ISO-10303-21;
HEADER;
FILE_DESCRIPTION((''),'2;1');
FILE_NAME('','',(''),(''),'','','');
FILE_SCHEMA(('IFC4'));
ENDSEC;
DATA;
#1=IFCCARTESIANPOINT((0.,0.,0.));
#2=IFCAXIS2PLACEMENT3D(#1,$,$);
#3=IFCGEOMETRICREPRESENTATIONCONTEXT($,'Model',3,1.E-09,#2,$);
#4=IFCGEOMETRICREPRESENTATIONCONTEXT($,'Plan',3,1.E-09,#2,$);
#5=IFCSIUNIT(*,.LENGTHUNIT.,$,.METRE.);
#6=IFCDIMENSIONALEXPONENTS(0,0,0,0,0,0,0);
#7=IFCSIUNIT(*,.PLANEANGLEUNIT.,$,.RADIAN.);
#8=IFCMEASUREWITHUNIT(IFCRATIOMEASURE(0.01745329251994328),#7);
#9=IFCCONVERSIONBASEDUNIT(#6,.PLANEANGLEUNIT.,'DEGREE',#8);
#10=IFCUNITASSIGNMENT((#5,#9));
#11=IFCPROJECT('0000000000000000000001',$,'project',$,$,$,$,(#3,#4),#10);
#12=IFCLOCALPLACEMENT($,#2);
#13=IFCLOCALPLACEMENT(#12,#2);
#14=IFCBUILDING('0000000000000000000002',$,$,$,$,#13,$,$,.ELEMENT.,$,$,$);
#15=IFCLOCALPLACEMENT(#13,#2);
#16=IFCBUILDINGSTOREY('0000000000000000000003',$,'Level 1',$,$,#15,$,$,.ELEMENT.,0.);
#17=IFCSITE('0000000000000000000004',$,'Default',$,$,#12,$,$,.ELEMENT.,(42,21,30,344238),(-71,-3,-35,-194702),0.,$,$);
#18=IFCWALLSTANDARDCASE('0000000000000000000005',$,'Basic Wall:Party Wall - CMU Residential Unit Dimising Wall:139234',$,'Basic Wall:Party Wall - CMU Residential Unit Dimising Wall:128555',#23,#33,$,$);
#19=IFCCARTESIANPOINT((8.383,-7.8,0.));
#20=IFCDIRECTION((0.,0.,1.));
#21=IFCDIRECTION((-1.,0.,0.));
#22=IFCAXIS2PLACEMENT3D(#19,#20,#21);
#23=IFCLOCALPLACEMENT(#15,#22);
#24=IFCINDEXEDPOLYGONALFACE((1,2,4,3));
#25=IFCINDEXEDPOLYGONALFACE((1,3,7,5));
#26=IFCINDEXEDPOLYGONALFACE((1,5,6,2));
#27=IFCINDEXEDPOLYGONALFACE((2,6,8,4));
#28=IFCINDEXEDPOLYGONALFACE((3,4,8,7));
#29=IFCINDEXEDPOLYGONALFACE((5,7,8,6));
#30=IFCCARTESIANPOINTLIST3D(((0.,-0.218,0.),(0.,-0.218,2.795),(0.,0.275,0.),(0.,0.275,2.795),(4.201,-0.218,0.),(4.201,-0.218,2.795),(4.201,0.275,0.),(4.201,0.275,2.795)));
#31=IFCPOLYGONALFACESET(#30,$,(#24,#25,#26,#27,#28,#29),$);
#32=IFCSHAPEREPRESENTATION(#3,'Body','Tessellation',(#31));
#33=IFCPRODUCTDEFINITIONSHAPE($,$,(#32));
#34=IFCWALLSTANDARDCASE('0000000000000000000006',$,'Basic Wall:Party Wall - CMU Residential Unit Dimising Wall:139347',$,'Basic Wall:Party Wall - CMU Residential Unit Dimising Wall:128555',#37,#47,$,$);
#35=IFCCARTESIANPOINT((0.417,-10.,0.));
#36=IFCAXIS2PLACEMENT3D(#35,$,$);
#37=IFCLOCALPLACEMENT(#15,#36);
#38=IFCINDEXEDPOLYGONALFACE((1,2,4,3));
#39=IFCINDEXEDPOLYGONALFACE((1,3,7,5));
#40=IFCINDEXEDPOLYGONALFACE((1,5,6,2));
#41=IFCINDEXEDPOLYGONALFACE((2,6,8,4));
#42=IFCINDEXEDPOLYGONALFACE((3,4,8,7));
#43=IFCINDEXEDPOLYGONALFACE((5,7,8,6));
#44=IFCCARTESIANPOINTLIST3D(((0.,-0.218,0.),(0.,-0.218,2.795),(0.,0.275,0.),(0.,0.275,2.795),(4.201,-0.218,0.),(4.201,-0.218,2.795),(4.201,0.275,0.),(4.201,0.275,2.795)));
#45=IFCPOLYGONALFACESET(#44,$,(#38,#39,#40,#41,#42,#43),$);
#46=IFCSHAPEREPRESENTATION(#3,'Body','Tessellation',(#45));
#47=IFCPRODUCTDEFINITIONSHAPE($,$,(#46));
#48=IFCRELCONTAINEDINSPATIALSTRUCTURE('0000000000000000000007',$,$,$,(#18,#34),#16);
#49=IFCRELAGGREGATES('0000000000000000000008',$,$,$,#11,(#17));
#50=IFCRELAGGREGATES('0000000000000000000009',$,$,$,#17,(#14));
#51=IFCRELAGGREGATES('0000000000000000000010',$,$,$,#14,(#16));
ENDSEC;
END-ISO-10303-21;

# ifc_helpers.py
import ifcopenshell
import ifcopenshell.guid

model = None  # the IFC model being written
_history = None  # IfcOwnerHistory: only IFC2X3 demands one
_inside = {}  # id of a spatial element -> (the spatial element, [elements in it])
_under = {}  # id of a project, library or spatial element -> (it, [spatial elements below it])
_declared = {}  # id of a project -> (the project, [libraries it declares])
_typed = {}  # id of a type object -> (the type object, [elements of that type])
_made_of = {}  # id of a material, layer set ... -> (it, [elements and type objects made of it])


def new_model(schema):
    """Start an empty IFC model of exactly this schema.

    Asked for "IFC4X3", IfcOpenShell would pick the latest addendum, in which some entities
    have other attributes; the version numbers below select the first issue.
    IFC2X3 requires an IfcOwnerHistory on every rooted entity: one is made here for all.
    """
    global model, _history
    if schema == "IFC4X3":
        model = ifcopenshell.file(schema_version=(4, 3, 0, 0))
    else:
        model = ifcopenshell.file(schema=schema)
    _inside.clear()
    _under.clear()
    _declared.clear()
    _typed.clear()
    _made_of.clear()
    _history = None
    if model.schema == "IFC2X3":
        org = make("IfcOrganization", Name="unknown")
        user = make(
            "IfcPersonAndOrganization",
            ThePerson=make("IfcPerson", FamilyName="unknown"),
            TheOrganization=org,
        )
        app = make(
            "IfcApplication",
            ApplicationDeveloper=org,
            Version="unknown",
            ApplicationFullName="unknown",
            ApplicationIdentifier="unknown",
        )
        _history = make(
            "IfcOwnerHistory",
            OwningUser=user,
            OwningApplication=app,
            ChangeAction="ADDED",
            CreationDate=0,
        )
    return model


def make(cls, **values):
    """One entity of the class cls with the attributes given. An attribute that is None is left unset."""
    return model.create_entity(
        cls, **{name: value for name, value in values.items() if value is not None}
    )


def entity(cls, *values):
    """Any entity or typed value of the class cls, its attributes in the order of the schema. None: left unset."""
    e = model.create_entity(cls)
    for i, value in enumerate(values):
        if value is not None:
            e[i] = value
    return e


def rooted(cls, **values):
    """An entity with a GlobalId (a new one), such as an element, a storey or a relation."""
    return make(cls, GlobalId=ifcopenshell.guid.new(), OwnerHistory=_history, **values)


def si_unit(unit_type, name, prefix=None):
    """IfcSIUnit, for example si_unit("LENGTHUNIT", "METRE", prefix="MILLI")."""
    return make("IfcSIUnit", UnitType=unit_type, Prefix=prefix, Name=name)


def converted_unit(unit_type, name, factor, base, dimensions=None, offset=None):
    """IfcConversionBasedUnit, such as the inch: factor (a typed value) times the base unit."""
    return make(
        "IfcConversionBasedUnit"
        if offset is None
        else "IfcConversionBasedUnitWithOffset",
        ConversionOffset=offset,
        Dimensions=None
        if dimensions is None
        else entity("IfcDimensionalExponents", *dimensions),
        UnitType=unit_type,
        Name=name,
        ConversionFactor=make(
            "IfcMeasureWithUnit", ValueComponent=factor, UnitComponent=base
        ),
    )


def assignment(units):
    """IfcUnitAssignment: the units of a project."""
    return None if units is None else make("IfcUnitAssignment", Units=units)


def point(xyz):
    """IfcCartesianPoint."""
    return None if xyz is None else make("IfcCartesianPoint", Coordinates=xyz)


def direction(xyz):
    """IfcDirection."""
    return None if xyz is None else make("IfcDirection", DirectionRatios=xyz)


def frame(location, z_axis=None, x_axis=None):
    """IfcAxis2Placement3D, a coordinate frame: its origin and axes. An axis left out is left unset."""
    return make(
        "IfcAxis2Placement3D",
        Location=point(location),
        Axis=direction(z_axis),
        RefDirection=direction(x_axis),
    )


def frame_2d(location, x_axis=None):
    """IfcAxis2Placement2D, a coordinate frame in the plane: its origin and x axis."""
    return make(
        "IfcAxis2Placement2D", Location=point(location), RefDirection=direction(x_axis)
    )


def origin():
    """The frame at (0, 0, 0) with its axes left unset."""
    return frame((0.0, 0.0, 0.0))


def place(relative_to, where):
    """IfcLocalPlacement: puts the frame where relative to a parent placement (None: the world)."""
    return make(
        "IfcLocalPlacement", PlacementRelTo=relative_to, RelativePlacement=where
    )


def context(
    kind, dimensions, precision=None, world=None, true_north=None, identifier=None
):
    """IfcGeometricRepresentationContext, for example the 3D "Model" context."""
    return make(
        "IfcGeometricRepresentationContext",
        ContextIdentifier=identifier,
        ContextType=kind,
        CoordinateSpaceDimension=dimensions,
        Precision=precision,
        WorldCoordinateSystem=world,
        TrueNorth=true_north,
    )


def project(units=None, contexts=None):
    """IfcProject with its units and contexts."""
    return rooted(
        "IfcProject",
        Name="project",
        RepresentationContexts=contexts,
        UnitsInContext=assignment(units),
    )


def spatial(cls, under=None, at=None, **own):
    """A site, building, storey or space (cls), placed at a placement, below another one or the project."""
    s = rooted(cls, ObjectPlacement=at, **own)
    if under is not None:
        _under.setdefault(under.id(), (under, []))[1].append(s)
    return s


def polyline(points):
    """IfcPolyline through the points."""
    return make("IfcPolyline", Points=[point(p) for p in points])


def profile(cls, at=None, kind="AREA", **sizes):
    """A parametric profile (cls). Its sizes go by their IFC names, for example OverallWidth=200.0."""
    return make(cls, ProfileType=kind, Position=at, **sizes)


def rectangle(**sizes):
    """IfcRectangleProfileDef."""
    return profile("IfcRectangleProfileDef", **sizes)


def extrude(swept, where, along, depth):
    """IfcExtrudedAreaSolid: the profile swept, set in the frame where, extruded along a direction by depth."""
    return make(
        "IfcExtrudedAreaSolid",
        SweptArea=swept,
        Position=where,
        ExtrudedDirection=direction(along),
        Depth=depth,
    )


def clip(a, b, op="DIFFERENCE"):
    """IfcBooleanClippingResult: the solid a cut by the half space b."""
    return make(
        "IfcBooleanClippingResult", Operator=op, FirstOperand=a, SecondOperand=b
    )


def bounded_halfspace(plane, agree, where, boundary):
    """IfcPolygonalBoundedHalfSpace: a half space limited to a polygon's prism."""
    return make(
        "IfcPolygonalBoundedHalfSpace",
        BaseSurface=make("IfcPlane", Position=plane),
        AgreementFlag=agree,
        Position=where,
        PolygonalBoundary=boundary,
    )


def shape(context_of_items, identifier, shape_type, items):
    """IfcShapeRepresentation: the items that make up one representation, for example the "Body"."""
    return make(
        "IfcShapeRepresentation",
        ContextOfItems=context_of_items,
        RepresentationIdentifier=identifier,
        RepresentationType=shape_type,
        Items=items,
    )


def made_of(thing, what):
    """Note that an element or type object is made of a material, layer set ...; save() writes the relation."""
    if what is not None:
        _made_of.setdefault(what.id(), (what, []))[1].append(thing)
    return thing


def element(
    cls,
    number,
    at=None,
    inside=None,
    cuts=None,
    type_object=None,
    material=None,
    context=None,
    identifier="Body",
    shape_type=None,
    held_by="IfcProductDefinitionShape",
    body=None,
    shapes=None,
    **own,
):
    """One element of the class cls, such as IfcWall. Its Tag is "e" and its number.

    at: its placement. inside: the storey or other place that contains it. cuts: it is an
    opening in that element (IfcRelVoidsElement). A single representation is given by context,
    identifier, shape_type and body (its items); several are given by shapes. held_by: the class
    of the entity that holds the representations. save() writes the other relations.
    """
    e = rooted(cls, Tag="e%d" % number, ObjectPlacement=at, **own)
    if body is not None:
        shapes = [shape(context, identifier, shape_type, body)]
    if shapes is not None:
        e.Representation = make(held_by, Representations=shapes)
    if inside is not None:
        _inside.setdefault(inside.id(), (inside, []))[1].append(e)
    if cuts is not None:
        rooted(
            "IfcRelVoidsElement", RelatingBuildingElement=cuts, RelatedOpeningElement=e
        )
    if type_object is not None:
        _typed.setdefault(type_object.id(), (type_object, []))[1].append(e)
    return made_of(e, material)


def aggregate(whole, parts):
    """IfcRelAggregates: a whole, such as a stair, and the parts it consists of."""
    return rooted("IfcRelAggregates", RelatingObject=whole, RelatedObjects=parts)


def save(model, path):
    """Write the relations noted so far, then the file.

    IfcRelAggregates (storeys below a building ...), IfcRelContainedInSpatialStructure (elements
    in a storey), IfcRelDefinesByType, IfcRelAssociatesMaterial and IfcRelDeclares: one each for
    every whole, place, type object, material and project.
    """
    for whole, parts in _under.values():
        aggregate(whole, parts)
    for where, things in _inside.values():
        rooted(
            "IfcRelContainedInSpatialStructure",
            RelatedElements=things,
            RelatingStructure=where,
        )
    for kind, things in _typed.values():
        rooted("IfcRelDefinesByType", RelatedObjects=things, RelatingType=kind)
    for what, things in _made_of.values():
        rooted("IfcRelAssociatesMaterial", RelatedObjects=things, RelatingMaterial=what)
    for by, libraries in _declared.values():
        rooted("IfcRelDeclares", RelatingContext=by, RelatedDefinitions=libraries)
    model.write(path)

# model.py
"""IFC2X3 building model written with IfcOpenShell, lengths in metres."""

from ifc_helpers import new_model, entity, si_unit, converted_unit, frame, frame_2d, origin, place, context, project, spatial, polyline, rectangle, extrude, clip, bounded_halfspace, element, save


model = new_model("IFC2X3")

# Units and contexts
model_context = context("Model", 3, precision=1e-09, world=origin())
plan_context = context("Plan", 3, precision=1e-09, world=origin())
ifc_project = project(units=[si_unit("LENGTHUNIT", "METRE"), converted_unit("PLANEANGLEUNIT", "DEGREE", entity("IfcRatioMeasure", 0.01745329251994328), si_unit("PLANEANGLEUNIT", "RADIAN"), dimensions=[0, 0, 0, 0, 0, 0, 0])], contexts=[model_context, plan_context])

# Site, building, storey
site_placement = place(None, origin())
site = spatial("IfcSite", under=ifc_project, at=site_placement, Name="Default", CompositionType="ELEMENT", RefLatitude=(42, 21, 30, 344238), RefLongitude=(-71, -3, -35, -194702), RefElevation=0.0)
building_placement = place(site_placement, origin())
building = spatial("IfcBuilding", under=site, at=building_placement, CompositionType="ELEMENT")
storey_placement = place(building_placement, origin())
storey = spatial("IfcBuildingStorey", under=building, at=storey_placement, Name="Level 1", CompositionType="ELEMENT", Elevation=0.0)

# Walls
wall_1_placement = place(storey_placement, frame((8.383, -7.8, 0.0), z_axis=(0.0, 0.0, 1.0), x_axis=(-1.0, 0.0, 0.0)))
element("IfcWallStandardCase", 1, at=wall_1_placement, inside=storey, Name="Basic Wall:Party Wall - CMU Residential Unit Dimising Wall:139234", ObjectType="Basic Wall:Party Wall - CMU Residential Unit Dimising Wall:128555", context=model_context, shape_type="Clipping", body=[
    clip(clip(extrude(rectangle(XDim=4.201, YDim=0.55, at=frame_2d((2.1005, 0.0), x_axis=(-1.0, 0.0))), origin(), (0.0, 0.0, 1.0), 2.795), bounded_halfspace(frame((0.0, -0.218, 2.795), z_axis=(0.0, 1.0, 0.0), x_axis=(-1.0, 0.0, 0.0)), True, frame((0.0, -0.218, 2.795), z_axis=(0.0, 1.0, 0.0), x_axis=(-1.0, 0.0, 0.0)), polyline([(0.0, 0.0), (-3.708, 0.0), (-4.201, 0.0), (-4.201, -2.795), (0.0, -2.795), (0.0, 0.0)]))), bounded_halfspace(frame((4.201, 0.275, 0.0), z_axis=(-1.0, 0.0, 0.0), x_axis=(0.0, -1.0, 0.0)), True, frame((4.201, 0.275, 0.0), z_axis=(-1.0, 0.0, 0.0), x_axis=(0.0, -1.0, 0.0)), polyline([(0.0, 0.0), (0.493, 0.0), (0.493, 2.795), (0.0, 2.795), (0.0, 0.0)]))),
])
wall_2_placement = place(storey_placement, frame((0.417, -10.0, 0.0)))
element("IfcWallStandardCase", 2, at=wall_2_placement, inside=storey, Name="Basic Wall:Party Wall - CMU Residential Unit Dimising Wall:139347", ObjectType="Basic Wall:Party Wall - CMU Residential Unit Dimising Wall:128555", context=model_context, shape_type="Clipping", body=[
    clip(clip(extrude(rectangle(XDim=4.201, YDim=0.55, at=frame_2d((2.1005, 0.0), x_axis=(-1.0, 0.0))), origin(), (0.0, 0.0, 1.0), 2.795), bounded_halfspace(frame((0.0, -0.218, 0.0), z_axis=(0.0, 1.0, 0.0), x_axis=(-1.0, 0.0, 0.0)), True, frame((0.0, -0.218, 0.0), z_axis=(0.0, 1.0, 0.0), x_axis=(-1.0, 0.0, 0.0)), polyline([(0.0, 0.0), (0.0, 2.795), (-4.201, 2.795), (-4.201, 0.0), (0.0, 0.0)]))), bounded_halfspace(frame((4.201, 0.275, 0.0), z_axis=(-1.0, 0.0, 0.0), x_axis=(0.0, -1.0, 0.0)), True, frame((4.201, 0.275, 0.0), z_axis=(-1.0, 0.0, 0.0), x_axis=(0.0, -1.0, 0.0)), polyline([(0.0, 0.0), (0.493, 0.0), (0.493, 2.795), (0.0, 2.795), (0.0, 0.0)]))),
])

save(model, "model.ifc")
